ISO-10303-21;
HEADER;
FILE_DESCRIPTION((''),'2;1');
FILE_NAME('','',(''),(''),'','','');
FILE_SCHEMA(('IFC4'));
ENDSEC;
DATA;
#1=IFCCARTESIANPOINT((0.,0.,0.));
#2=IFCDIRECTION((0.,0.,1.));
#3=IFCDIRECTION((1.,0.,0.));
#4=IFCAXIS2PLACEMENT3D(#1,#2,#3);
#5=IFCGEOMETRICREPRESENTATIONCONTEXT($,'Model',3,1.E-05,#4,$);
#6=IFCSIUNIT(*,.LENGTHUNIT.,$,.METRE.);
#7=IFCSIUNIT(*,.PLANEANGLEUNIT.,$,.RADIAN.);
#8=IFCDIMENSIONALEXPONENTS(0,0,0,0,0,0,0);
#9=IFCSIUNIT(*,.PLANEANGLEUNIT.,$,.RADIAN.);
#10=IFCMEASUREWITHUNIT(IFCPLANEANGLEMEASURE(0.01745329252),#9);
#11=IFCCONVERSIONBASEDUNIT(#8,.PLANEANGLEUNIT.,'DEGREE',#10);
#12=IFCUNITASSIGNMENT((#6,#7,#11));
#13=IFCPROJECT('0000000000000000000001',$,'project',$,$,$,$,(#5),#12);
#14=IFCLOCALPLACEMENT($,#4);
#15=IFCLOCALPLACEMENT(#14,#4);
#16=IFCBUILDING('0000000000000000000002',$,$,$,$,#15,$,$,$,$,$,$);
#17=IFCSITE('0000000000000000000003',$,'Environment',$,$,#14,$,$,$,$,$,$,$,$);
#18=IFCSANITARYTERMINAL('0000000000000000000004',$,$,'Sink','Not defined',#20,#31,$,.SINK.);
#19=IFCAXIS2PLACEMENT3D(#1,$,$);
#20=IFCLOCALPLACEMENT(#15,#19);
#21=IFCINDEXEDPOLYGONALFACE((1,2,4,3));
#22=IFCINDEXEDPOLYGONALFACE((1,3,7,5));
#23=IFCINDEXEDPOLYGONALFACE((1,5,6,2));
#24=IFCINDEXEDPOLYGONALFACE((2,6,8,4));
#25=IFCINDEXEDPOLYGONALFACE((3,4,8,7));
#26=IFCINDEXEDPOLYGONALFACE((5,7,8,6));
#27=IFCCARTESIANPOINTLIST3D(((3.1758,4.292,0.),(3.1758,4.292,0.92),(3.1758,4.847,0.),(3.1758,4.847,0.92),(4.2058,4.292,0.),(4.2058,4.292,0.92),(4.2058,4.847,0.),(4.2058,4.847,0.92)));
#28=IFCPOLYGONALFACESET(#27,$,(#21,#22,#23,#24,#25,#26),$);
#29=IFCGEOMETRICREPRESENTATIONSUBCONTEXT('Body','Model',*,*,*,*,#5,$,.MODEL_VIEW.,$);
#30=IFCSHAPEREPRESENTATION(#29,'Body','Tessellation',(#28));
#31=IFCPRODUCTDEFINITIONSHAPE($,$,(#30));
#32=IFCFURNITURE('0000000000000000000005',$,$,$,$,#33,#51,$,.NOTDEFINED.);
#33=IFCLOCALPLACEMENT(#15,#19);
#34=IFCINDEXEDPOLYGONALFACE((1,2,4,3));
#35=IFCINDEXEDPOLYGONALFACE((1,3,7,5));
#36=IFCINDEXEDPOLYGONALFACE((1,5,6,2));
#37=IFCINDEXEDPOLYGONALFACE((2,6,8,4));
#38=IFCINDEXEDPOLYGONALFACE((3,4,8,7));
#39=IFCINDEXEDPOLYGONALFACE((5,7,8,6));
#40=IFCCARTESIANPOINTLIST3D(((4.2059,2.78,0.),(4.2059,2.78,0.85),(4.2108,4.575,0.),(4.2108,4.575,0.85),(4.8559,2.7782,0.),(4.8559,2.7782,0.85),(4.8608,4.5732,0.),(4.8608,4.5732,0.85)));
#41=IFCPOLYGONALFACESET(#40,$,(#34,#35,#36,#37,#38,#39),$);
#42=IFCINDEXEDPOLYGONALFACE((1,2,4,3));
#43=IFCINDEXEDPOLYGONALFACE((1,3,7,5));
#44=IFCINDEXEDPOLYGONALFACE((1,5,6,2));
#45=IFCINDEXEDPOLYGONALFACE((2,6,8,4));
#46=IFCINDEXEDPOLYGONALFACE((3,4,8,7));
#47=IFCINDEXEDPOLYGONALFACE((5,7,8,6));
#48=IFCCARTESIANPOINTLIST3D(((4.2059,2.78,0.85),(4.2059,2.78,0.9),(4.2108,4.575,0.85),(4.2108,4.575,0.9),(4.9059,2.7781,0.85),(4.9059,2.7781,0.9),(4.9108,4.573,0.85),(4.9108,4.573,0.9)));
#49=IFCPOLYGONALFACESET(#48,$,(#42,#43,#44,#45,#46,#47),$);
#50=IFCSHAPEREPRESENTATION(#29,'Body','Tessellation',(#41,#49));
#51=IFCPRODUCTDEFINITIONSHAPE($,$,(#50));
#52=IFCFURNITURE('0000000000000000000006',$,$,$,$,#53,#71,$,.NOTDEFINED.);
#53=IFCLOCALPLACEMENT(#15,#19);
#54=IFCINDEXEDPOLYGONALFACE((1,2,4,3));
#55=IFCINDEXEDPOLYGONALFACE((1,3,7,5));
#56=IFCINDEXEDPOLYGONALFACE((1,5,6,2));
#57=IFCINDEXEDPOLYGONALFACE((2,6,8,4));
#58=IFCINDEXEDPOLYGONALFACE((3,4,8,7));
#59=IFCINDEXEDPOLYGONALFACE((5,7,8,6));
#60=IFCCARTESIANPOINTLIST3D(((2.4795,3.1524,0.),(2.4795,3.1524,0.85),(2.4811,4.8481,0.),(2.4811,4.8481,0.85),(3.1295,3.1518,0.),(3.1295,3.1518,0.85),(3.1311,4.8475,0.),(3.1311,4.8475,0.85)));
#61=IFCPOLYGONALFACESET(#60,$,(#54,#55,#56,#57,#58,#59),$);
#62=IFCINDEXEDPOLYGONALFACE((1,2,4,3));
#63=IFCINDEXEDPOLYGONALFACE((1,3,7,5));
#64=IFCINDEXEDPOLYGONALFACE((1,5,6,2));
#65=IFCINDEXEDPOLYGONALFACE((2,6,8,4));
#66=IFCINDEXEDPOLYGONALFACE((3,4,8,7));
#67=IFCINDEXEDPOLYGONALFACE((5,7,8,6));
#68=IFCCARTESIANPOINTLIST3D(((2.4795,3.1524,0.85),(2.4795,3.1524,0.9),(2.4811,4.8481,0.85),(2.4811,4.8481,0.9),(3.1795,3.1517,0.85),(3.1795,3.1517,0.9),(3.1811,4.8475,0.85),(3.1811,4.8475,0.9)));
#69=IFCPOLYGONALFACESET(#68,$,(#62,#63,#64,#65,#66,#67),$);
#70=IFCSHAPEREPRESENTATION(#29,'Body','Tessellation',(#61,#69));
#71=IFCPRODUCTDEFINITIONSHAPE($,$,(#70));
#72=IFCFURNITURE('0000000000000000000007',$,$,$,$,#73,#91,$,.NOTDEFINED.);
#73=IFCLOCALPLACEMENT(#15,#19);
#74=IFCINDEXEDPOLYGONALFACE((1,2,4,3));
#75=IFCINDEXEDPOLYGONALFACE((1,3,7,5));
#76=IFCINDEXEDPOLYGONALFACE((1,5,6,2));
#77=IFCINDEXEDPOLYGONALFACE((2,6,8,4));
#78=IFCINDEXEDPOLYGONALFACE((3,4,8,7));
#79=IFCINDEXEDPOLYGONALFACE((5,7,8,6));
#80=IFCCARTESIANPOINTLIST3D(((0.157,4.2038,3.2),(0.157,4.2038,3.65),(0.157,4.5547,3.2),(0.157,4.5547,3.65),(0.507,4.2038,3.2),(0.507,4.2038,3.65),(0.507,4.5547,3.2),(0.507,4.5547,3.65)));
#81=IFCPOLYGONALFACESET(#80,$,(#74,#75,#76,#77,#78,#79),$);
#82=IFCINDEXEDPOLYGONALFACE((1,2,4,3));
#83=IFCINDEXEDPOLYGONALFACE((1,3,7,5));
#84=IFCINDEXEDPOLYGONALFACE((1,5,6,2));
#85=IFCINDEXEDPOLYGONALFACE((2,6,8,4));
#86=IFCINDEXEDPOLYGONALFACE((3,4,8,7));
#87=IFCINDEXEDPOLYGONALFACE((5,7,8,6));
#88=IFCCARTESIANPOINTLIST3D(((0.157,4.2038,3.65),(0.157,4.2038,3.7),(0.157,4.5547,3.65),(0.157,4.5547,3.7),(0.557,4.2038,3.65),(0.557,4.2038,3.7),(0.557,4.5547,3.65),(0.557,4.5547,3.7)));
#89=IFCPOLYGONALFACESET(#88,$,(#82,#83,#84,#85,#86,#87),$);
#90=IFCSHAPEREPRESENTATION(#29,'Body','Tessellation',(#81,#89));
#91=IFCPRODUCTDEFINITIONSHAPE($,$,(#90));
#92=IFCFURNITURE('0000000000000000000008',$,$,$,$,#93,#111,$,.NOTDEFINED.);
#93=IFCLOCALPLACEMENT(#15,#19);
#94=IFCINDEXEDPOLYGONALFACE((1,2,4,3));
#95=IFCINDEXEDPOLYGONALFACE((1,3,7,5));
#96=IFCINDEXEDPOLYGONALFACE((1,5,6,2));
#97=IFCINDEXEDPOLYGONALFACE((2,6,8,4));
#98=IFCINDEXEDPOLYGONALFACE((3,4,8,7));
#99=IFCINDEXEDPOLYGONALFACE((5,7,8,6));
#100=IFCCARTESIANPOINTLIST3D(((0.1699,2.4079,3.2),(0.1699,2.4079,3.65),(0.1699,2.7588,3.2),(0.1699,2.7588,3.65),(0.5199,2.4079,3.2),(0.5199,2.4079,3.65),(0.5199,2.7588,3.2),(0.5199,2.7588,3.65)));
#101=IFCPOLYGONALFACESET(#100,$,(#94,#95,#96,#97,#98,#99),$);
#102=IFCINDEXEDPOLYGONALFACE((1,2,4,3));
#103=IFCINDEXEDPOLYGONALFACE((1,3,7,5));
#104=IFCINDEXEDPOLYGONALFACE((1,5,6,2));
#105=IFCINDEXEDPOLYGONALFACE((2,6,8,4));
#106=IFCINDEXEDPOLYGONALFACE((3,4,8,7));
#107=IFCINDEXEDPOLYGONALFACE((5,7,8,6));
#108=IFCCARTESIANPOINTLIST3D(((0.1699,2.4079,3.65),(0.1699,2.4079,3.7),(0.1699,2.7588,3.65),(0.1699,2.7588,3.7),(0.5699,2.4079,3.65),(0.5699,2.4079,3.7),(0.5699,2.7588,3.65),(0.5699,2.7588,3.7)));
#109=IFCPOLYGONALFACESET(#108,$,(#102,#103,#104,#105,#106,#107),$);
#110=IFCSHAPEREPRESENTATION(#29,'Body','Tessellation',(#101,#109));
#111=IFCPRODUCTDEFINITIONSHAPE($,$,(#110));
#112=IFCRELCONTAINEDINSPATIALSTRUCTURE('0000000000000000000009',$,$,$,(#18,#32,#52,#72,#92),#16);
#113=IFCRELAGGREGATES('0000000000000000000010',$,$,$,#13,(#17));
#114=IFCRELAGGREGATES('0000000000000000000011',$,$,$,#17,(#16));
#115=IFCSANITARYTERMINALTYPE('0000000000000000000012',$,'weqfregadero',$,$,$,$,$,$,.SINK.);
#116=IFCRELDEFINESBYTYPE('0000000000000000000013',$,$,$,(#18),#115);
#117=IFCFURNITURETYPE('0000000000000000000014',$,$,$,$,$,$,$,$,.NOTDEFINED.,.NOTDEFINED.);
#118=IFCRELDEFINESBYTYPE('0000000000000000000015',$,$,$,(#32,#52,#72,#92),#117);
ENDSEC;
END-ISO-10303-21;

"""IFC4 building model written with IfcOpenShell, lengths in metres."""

from ifc_helpers import new_model, entity, si_unit, converted_unit, frame, origin_with_axes, place, context, subcontext, project, spatial, polyline, outline, extrude, source, transform, mapped, type_object, element, save


model = new_model("IFC4")

# Units and contexts
model_context = context("Model", 3, precision=1e-05, world=origin_with_axes())
body_context = subcontext(model_context, "Body", "Model", "MODEL_VIEW")
ifc_project = project(units=[si_unit("LENGTHUNIT", "METRE"), si_unit("PLANEANGLEUNIT", "RADIAN"), converted_unit("PLANEANGLEUNIT", "DEGREE", entity("IfcPlaneAngleMeasure", 0.01745329252), si_unit("PLANEANGLEUNIT", "RADIAN"), dimensions=[0, 0, 0, 0, 0, 0, 0])], contexts=[model_context])

# Site, building
site_placement = place(None, origin_with_axes())
site = spatial("IfcSite", under=ifc_project, at=site_placement, Name="Environment")
building_placement = place(site_placement, origin_with_axes())
building = spatial("IfcBuilding", under=site, at=building_placement)

# Sanitary terminal
sanitary_terminal_type = type_object("IfcSanitaryTerminalType", Name="weqfregadero", PredefinedType="SINK")
shared_shape = source(origin_with_axes(), body_context, "Body", "SolidModel", [
    extrude(outline(polyline([(0.0, -0.515), (0.555, -0.515), (0.555, 0.515), (0.0, 0.515), (0.0, -0.515)])), frame((0.0, 0.0, -0.915), z_axis=(0.0, 0.0, 1.0), x_axis=(1.0, 0.0, 0.0)), (0.0, 0.0, 1.0), 0.92),
])
sanitary_terminal_placement = place(building_placement, frame((3.6908, 4.847, 0.915), z_axis=(0.0, 0.0, 1.0), x_axis=(0.0, -1.0, 0.0)))
element("IfcSanitaryTerminal", 1, at=sanitary_terminal_placement, inside=building, type_object=sanitary_terminal_type, Description="Sink", ObjectType="Not defined", PredefinedType="SINK", context=body_context, shape_type="MappedRepresentation", body=[
    mapped(shared_shape, transform((0.0, 0.0, 0.0), x_axis=(1.0, 0.0, 0.0), y_axis=(0.0, 1.0, 0.0), z_axis=(0.0, 0.0, 1.0))),
])

# Furniture
furniture_type_1 = type_object("IfcFurnitureType", PredefinedType="NOTDEFINED")
furniture_1_placement = place(building_placement, frame((4.5333, 3.6766, 0.0), z_axis=(0.0, 0.0, 1.0), x_axis=(0.002774, 0.999996, 0.0)))
element("IfcFurniture", 2, at=furniture_1_placement, inside=building, type_object=furniture_type_1, PredefinedType="NOTDEFINED", context=body_context, shape_type="SolidModel", body=[
    extrude(outline(polyline([(-0.8975, -0.325), (0.8975, -0.325), (0.8975, 0.325), (-0.8975, 0.325), (-0.8975, -0.325)])), origin_with_axes(), (0.0, 0.0, 1.0), 0.85),
    extrude(outline(polyline([(-0.8975, -0.375), (0.8975, -0.375), (0.8975, 0.325), (-0.8975, 0.325), (-0.8975, -0.375)])), frame((0.0, 0.0, 0.85), z_axis=(0.0, 0.0, 1.0), x_axis=(1.0, 0.0, 0.0)), (0.0, 0.0, 1.0), 0.05),
])
furniture_2_placement = place(building_placement, frame((2.8053, 4.0, 0.0), z_axis=(0.0, 0.0, 1.0), x_axis=(0.000911, 1.0, 0.0)))
element("IfcFurniture", 3, at=furniture_2_placement, inside=building, type_object=furniture_type_1, PredefinedType="NOTDEFINED", context=body_context, shape_type="SolidModel", body=[
    extrude(outline(polyline([(-0.8479, -0.325), (0.8479, -0.325), (0.8479, 0.325), (-0.8479, 0.325), (-0.8479, -0.325)])), origin_with_axes(), (0.0, 0.0, 1.0), 0.85),
    extrude(outline(polyline([(-0.8479, -0.375), (0.8479, -0.375), (0.8479, 0.325), (-0.8479, 0.325), (-0.8479, -0.375)])), frame((0.0, 0.0, 0.85), z_axis=(0.0, 0.0, 1.0), x_axis=(1.0, 0.0, 0.0)), (0.0, 0.0, 1.0), 0.05),
])
for number, where, z_axis, x_axis in (
    (4, (0.332, 4.3793, 3.2), (0.0, 0.0, 1.0), (0.0, 1.0, 0.0)),
    (5, (0.3449, 2.5833, 3.2), (0.0, 0.0, 1.0), (0.0, 1.0, 0.0)),
):
    element("IfcFurniture", number, at=place(building_placement, frame(where, z_axis=z_axis, x_axis=x_axis)), inside=building, type_object=furniture_type_1, PredefinedType="NOTDEFINED", context=body_context, shape_type="SolidModel", body=[
        extrude(outline(polyline([(-0.1755, -0.175), (0.1755, -0.175), (0.1755, 0.175), (-0.1755, 0.175), (-0.1755, -0.175)])), origin_with_axes(), (0.0, 0.0, 1.0), 0.45),
        extrude(outline(polyline([(-0.1755, -0.225), (0.1755, -0.225), (0.1755, 0.175), (-0.1755, 0.175), (-0.1755, -0.225)])), frame((0.0, 0.0, 0.45), z_axis=(0.0, 0.0, 1.0), x_axis=(1.0, 0.0, 0.0)), (0.0, 0.0, 1.0), 0.05),
    ])

save(model, "model.ifc")
